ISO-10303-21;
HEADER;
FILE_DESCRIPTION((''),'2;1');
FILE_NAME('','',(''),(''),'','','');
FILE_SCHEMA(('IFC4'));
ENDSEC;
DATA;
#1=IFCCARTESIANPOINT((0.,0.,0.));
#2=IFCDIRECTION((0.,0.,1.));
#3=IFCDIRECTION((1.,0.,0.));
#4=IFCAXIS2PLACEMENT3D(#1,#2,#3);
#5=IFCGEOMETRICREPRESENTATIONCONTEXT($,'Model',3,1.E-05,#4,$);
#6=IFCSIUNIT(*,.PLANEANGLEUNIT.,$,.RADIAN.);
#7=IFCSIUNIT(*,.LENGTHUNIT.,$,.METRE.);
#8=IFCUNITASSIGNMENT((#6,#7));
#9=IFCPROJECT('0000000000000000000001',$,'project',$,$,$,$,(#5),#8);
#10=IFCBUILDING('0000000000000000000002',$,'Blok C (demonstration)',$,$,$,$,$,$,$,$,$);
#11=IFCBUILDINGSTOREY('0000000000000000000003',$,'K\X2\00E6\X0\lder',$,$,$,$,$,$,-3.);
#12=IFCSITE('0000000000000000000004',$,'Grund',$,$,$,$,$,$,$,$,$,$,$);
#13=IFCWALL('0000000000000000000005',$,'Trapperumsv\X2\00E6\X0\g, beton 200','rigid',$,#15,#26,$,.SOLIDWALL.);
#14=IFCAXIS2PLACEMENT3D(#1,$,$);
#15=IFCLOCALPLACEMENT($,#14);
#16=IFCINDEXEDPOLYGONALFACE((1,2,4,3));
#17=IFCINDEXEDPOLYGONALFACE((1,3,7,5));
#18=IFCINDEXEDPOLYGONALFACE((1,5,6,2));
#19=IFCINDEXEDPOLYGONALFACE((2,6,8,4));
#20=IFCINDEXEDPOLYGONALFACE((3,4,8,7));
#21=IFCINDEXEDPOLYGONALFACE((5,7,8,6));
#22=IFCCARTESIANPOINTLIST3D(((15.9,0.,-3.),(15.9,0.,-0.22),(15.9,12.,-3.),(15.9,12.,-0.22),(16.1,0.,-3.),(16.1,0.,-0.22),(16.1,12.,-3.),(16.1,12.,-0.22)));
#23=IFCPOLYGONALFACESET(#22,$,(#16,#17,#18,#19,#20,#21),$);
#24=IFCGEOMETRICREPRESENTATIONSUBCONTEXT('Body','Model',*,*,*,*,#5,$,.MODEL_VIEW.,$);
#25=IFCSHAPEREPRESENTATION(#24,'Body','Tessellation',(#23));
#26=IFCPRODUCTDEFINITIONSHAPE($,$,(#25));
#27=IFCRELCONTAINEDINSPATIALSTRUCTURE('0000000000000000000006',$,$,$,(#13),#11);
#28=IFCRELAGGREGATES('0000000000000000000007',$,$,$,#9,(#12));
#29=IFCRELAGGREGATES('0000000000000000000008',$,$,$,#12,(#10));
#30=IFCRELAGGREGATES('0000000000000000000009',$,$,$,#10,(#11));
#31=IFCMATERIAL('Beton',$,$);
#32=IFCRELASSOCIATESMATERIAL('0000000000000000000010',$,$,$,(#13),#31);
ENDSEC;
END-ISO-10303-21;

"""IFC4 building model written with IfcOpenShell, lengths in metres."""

from ifc_helpers import new_model, si_unit, frame, origin_with_axes, place, context, subcontext, project, spatial, polyline, outline, extrude, material, element, save


model = new_model("IFC4")

# Units and contexts
model_context = context("Model", 3, precision=1e-05, world=origin_with_axes())
body_context = subcontext(model_context, "Body", "Model", "MODEL_VIEW")
ifc_project = project(units=[si_unit("PLANEANGLEUNIT", "RADIAN"), si_unit("LENGTHUNIT", "METRE")], contexts=[model_context])

# Site, building, storey
site = spatial("IfcSite", under=ifc_project, Name="Grund")
building = spatial("IfcBuilding", under=site, Name="Blok C (demonstration)")
storey = spatial("IfcBuildingStorey", under=building, Name="Kælder", Elevation=-3.0)

# Wall
ifc_material_1 = material(Name="Beton")
wall_placement = place(None, origin_with_axes())
element("IfcWall", 1, at=wall_placement, inside=storey, material=ifc_material_1, Name="Trapperumsvæg, beton 200", Description="rigid", PredefinedType="SOLIDWALL", context=body_context, shape_type="SweptSolid", body=[
    extrude(outline(polyline([(15.9, 0.0), (16.1, 0.0), (16.1, 12.0), (15.9, 12.0), (15.9, 0.0)])), frame((0.0, 0.0, -3.0)), (0.0, 0.0, 1.0), 2.78),
])

save(model, "model.ifc")
